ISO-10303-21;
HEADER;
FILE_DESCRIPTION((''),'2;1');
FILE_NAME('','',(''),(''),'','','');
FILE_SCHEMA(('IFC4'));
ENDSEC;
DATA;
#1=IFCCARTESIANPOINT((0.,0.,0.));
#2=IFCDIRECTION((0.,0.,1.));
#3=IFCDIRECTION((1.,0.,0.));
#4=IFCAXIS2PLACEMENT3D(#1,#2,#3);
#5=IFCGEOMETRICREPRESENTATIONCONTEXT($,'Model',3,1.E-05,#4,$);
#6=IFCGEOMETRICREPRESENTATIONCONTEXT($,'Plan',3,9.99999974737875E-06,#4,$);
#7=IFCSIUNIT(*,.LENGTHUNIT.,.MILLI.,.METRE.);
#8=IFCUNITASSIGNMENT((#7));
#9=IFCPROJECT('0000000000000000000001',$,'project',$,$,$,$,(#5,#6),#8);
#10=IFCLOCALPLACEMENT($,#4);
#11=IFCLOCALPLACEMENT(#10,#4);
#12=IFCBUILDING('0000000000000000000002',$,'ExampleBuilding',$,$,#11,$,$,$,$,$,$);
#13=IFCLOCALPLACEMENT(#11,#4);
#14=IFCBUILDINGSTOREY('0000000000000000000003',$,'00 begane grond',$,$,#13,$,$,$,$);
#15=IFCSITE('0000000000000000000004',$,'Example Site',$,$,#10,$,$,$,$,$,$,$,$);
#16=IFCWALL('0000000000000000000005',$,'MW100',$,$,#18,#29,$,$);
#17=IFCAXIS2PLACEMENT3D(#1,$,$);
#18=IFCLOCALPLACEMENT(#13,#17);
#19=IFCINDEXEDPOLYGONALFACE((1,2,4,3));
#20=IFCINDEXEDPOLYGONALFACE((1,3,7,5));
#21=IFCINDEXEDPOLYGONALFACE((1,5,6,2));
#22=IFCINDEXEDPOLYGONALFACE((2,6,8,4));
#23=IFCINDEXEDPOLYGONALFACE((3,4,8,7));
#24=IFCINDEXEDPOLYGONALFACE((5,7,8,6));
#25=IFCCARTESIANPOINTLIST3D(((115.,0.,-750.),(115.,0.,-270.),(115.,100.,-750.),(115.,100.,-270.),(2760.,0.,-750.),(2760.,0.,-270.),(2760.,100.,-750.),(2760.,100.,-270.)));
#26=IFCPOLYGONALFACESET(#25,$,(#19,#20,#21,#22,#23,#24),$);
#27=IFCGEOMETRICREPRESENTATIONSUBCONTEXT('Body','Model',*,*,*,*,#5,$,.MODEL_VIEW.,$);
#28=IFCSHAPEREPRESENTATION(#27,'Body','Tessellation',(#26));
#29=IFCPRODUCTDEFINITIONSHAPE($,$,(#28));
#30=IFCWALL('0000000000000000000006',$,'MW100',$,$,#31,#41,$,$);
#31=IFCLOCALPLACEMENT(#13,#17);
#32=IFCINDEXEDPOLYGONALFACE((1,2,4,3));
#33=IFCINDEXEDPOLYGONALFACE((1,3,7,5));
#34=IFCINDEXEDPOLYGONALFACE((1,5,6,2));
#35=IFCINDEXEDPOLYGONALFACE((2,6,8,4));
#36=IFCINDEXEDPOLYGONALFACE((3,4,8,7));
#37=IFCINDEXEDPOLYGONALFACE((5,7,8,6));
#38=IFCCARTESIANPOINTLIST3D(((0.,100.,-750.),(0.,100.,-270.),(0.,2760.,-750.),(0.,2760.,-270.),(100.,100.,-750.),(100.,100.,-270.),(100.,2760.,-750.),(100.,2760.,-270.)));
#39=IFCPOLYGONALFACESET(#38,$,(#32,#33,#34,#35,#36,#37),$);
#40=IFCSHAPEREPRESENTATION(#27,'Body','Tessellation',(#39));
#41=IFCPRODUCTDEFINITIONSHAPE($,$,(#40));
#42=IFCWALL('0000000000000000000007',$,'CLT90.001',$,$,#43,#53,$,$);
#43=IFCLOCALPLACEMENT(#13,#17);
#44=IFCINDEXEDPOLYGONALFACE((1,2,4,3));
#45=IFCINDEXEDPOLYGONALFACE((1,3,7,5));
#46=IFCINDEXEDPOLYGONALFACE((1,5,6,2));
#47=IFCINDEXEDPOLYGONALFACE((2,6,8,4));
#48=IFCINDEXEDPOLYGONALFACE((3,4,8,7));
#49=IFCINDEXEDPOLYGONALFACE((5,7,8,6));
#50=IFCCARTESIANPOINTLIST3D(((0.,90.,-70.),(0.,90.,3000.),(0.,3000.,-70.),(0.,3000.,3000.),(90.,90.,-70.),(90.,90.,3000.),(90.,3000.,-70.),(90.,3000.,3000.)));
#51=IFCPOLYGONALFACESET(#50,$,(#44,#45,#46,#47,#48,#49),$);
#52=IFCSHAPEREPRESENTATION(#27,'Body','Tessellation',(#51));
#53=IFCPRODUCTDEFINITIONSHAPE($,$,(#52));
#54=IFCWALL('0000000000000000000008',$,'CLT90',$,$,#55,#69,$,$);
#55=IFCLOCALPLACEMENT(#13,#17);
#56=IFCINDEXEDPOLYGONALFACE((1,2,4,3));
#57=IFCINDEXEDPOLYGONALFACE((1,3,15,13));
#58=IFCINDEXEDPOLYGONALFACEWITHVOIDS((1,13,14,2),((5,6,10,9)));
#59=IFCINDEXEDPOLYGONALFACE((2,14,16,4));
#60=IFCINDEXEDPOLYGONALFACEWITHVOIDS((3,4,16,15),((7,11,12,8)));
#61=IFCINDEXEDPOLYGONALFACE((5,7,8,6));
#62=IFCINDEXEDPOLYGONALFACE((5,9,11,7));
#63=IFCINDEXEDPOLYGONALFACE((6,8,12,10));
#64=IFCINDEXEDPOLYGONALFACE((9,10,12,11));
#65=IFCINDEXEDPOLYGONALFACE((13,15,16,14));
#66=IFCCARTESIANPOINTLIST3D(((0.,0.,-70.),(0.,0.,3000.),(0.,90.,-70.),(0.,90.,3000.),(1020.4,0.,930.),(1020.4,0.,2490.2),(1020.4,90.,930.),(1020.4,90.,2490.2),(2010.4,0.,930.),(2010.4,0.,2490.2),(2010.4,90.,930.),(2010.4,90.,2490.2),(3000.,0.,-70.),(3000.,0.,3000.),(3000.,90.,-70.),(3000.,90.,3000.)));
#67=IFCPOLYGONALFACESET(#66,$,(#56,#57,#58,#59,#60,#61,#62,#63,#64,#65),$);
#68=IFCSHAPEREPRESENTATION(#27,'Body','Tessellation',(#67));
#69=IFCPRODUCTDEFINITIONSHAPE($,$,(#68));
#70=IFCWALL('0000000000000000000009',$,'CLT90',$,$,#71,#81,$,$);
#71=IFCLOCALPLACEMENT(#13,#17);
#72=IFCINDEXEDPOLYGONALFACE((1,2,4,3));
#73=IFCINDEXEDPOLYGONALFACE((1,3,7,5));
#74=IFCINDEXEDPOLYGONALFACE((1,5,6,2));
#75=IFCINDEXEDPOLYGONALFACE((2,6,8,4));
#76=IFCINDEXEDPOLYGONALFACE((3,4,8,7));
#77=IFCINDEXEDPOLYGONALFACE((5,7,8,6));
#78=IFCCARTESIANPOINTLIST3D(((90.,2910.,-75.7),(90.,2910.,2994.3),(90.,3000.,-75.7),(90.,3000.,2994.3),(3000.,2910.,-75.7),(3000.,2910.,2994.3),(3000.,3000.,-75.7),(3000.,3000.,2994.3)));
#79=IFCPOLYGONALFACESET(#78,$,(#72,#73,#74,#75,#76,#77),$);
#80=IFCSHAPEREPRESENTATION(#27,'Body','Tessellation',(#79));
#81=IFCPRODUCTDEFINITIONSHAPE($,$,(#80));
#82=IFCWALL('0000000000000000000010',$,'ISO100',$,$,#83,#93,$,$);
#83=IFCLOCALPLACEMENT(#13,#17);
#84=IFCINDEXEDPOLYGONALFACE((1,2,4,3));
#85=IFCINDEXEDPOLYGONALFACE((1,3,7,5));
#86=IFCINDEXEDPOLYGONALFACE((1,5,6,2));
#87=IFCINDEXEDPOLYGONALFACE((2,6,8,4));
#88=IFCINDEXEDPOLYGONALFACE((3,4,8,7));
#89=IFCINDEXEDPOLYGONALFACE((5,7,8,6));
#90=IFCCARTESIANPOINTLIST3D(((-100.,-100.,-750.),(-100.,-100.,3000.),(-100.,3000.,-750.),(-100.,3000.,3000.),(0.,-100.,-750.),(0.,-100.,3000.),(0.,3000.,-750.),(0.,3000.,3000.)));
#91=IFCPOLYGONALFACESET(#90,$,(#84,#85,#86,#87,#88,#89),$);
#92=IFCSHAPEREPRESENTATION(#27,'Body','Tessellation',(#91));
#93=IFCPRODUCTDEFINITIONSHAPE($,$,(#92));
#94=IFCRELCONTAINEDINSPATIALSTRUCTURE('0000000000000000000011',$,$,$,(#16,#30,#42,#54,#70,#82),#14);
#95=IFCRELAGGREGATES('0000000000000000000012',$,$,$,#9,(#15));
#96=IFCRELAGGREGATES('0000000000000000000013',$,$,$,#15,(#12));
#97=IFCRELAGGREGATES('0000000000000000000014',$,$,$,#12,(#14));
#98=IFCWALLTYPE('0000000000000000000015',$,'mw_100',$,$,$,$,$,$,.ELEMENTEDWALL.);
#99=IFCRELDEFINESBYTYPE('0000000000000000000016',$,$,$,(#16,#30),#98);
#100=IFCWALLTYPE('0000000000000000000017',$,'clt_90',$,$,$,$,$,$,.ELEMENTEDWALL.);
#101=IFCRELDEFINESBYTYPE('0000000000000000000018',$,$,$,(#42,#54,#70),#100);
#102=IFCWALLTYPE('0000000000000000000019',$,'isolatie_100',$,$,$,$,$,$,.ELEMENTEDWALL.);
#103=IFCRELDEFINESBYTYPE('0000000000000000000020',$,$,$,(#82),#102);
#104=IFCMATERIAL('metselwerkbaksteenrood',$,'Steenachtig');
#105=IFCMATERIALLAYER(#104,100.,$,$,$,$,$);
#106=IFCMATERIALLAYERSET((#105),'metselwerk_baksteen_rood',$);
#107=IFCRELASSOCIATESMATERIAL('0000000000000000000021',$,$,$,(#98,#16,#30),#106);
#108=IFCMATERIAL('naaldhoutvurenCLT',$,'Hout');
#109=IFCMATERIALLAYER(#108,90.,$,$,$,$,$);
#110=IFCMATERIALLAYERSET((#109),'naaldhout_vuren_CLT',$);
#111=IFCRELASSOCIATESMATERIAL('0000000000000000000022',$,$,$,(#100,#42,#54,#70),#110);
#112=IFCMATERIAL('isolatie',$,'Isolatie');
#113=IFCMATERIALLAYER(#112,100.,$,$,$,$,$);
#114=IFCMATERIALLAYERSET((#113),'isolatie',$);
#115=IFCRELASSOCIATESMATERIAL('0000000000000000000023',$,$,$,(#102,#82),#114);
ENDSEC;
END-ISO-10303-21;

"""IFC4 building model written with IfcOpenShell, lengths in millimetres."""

from ifc_helpers import new_model, si_unit, frame, origin_with_axes, place, context, subcontext, project, spatial, line, indexed_curve, outline, extrude, clip, halfspace, source, transform, mapped, material, layer, layer_set, layer_usage, type_object, element, save


model = new_model("IFC4")

# Units and contexts
model_context = context("Model", 3, precision=1e-05, world=origin_with_axes())
plan_context = context("Plan", 3, precision=9.99999974737875e-06, world=origin_with_axes())
body_context = subcontext(model_context, "Body", "Model", "MODEL_VIEW")
ifc_project = project(units=[si_unit("LENGTHUNIT", "METRE", prefix="MILLI")], contexts=[model_context, plan_context])

# Site, building, storey
site_placement = place(None, frame((0.0, 0.0, 0.0), z_axis=(0.0, 0.0, 1.0), x_axis=(1.0, 0.0, 0.0)))
site = spatial("IfcSite", under=ifc_project, at=site_placement, Name="Example Site")
building_placement = place(site_placement, frame((0.0, 0.0, 0.0), z_axis=(0.0, 0.0, 1.0), x_axis=(1.0, 0.0, 0.0)))
building = spatial("IfcBuilding", under=site, at=building_placement, Name="ExampleBuilding")
storey_placement = place(building_placement, frame((0.0, 0.0, 0.0), z_axis=(0.0, 0.0, 1.0), x_axis=(1.0, 0.0, 0.0)))
storey = spatial("IfcBuildingStorey", under=building, at=storey_placement, Name="00 begane grond")

# Shared definitions
ifc_material_1 = material(Name="naaldhoutvurenCLT", Category="Hout")
ifc_material_2 = material(Name="isolatie", Category="Isolatie")

# Shared definitions
ifc_material_3 = material(Name="metselwerkbaksteenrood", Category="Steenachtig")
ifc_layer_1 = layer(ifc_material_3, 100.0)
ifc_layer_set_1 = layer_set([ifc_layer_1], Name="metselwerk_baksteen_rood")
wall_type_1 = type_object("IfcWallType", Name="mw_100", PredefinedType="ELEMENTEDWALL", material=ifc_layer_set_1)
shared_shape = source(origin_with_axes(), body_context, "Body", "SweptSolid", [
    extrude(outline(indexed_curve([(0.0, 0.0), (990.0, 0.0), (990.0, 1560.2), (0.0, 1560.2)], segments=[line(1, 2, 3, 4, 1)])), frame((0.0, -600.0, 0.0), z_axis=(0.0, -1.0, 0.0), x_axis=(1.0, 0.0, 0.0)), (0.0, 0.0, -1.0), 1200.0),
])

# Walls
ifc_layer_usage_1 = layer_usage(ifc_layer_set_1, "AXIS2", "POSITIVE", 0.0)
wall_1_placement = place(storey_placement, frame((115.0, 0.0, -750.0), z_axis=(0.0, 0.0, 1.0), x_axis=(1.0, 0.0, 0.0)))
element("IfcWall", 1, at=wall_1_placement, inside=storey, type_object=wall_type_1, material=ifc_layer_usage_1, Name="MW100", context=body_context, shape_type="Clipping", body=[
    clip(extrude(outline(indexed_curve([(0.0, 0.0), (0.0, 100.0), (2645.0, 100.0), (2645.0, 0.0), (0.0, 0.0)], self_intersect=False)), origin_with_axes(), (0.0, 0.0, 1.0), 480.0), halfspace(frame((0.0, 0.0, 480.0), z_axis=(0.0, 0.0, 1.0), x_axis=(-1.0, 0.0, 0.0)), False)),
])
ifc_layer_usage_2 = layer_usage(ifc_layer_set_1, "AXIS2", "POSITIVE", 0.0)
wall_2_placement = place(storey_placement, frame((100.0, 100.0, -750.0), z_axis=(0.0, 0.0, 1.0), x_axis=(0.0, 1.0, 0.0)))
element("IfcWall", 2, at=wall_2_placement, inside=storey, type_object=wall_type_1, material=ifc_layer_usage_2, Name="MW100", context=body_context, shape_type="Clipping", body=[
    clip(extrude(outline(indexed_curve([(0.0, 0.0), (0.0, 100.0), (2660.0, 100.0), (2660.0, 0.0), (0.0, 0.0)], self_intersect=False)), origin_with_axes(), (0.0, 0.0, 1.0), 480.0), halfspace(frame((0.0, 0.0, 480.0), z_axis=(0.0, 0.0, 1.0), x_axis=(-1.0, 0.0, 0.0)), False)),
])
ifc_layer_2 = layer(ifc_material_1, 90.0)
ifc_layer_set_2 = layer_set([ifc_layer_2], Name="naaldhout_vuren_CLT")
ifc_layer_usage_3 = layer_usage(ifc_layer_set_2, "AXIS2", "POSITIVE", 0.0)
wall_type_2 = type_object("IfcWallType", Name="clt_90", PredefinedType="ELEMENTEDWALL", material=ifc_layer_set_2)
wall_3_placement = place(storey_placement, frame((90.0, 90.0, -70.0), z_axis=(0.0, 0.0, 1.0), x_axis=(0.0, 1.0, 0.0)))
element("IfcWall", 3, at=wall_3_placement, inside=storey, type_object=wall_type_2, material=ifc_layer_usage_3, Name="CLT90.001", context=body_context, shape_type="SweptSolid", body=[
    extrude(outline(indexed_curve([(0.0, 0.0), (0.0, 90.0), (2910.0, 90.0), (2910.0, 0.0), (0.0, 0.0)], self_intersect=False)), origin_with_axes(), (0.0, 0.0, 1.0), 3070.0),
])

# Wall, opening
ifc_layer_usage_4 = layer_usage(ifc_layer_set_2, "AXIS2", "POSITIVE", 0.0)
wall_4_placement = place(storey_placement, frame((0.0, 0.0, -70.0), z_axis=(0.0, 0.0, 1.0), x_axis=(1.0, 0.0, 0.0)))
wall_4 = element("IfcWall", 4, at=wall_4_placement, inside=storey, type_object=wall_type_2, material=ifc_layer_usage_4, Name="CLT90", context=body_context, shape_type="SweptSolid", body=[
    extrude(outline(indexed_curve([(0.0, 0.0), (0.0, 90.0), (3000.0, 90.0), (3000.0, 0.0), (0.0, 0.0)], self_intersect=False)), origin_with_axes(), (0.0, 0.0, 1.0), 3070.0),
])
opening_1_placement = place(wall_4_placement, frame((1020.4, -185.0, 1000.0), z_axis=(0.0, 0.0, 1.0), x_axis=(1.0, 0.0, 0.0)))
element("IfcOpeningElement", 5, at=opening_1_placement, cuts=wall_4, PredefinedType="OPENING", context=body_context, shape_type="MappedRepresentation", body=[
    mapped(shared_shape, transform((0.0, 0.0, 0.0), x_axis=(1.0, 0.0, 0.0), y_axis=(0.0, 1.0, 0.0), z_axis=(0.0, 0.0, 1.0), scale=1.0)),
])

# Walls
ifc_layer_usage_5 = layer_usage(ifc_layer_set_2, "AXIS2", "POSITIVE", 0.0)
wall_5_placement = place(storey_placement, frame((90.0, 2910.0, -75.7), z_axis=(0.0, 0.0, 1.0), x_axis=(1.0, 0.0, 0.0)))
element("IfcWall", 6, at=wall_5_placement, inside=storey, type_object=wall_type_2, material=ifc_layer_usage_5, Name="CLT90", context=body_context, shape_type="SweptSolid", body=[
    extrude(outline(indexed_curve([(0.0, 0.0), (0.0, 90.0), (2910.0, 90.0), (2910.0, 0.0), (0.0, 0.0)], self_intersect=False)), origin_with_axes(), (0.0, 0.0, 1.0), 3070.0),
])
ifc_layer_3 = layer(ifc_material_2, 100.0)
ifc_layer_set_3 = layer_set([ifc_layer_3], Name="isolatie")
ifc_layer_usage_6 = layer_usage(ifc_layer_set_3, "AXIS2", "POSITIVE", 0.0)
wall_type_3 = type_object("IfcWallType", Name="isolatie_100", PredefinedType="ELEMENTEDWALL", material=ifc_layer_set_3)
wall_6_placement = place(storey_placement, frame((0.0, -100.0, -750.0), z_axis=(0.0, 0.0, 1.0), x_axis=(0.0, 1.0, 0.0)))
element("IfcWall", 7, at=wall_6_placement, inside=storey, type_object=wall_type_3, material=ifc_layer_usage_6, Name="ISO100", context=body_context, shape_type="SweptSolid", body=[
    extrude(outline(indexed_curve([(0.0, 0.0), (0.0, 100.0), (3100.0, 100.0), (3100.0, 0.0), (0.0, 0.0)], self_intersect=False)), origin_with_axes(), (0.0, 0.0, 1.0), 3750.0),
])

save(model, "model.ifc")
